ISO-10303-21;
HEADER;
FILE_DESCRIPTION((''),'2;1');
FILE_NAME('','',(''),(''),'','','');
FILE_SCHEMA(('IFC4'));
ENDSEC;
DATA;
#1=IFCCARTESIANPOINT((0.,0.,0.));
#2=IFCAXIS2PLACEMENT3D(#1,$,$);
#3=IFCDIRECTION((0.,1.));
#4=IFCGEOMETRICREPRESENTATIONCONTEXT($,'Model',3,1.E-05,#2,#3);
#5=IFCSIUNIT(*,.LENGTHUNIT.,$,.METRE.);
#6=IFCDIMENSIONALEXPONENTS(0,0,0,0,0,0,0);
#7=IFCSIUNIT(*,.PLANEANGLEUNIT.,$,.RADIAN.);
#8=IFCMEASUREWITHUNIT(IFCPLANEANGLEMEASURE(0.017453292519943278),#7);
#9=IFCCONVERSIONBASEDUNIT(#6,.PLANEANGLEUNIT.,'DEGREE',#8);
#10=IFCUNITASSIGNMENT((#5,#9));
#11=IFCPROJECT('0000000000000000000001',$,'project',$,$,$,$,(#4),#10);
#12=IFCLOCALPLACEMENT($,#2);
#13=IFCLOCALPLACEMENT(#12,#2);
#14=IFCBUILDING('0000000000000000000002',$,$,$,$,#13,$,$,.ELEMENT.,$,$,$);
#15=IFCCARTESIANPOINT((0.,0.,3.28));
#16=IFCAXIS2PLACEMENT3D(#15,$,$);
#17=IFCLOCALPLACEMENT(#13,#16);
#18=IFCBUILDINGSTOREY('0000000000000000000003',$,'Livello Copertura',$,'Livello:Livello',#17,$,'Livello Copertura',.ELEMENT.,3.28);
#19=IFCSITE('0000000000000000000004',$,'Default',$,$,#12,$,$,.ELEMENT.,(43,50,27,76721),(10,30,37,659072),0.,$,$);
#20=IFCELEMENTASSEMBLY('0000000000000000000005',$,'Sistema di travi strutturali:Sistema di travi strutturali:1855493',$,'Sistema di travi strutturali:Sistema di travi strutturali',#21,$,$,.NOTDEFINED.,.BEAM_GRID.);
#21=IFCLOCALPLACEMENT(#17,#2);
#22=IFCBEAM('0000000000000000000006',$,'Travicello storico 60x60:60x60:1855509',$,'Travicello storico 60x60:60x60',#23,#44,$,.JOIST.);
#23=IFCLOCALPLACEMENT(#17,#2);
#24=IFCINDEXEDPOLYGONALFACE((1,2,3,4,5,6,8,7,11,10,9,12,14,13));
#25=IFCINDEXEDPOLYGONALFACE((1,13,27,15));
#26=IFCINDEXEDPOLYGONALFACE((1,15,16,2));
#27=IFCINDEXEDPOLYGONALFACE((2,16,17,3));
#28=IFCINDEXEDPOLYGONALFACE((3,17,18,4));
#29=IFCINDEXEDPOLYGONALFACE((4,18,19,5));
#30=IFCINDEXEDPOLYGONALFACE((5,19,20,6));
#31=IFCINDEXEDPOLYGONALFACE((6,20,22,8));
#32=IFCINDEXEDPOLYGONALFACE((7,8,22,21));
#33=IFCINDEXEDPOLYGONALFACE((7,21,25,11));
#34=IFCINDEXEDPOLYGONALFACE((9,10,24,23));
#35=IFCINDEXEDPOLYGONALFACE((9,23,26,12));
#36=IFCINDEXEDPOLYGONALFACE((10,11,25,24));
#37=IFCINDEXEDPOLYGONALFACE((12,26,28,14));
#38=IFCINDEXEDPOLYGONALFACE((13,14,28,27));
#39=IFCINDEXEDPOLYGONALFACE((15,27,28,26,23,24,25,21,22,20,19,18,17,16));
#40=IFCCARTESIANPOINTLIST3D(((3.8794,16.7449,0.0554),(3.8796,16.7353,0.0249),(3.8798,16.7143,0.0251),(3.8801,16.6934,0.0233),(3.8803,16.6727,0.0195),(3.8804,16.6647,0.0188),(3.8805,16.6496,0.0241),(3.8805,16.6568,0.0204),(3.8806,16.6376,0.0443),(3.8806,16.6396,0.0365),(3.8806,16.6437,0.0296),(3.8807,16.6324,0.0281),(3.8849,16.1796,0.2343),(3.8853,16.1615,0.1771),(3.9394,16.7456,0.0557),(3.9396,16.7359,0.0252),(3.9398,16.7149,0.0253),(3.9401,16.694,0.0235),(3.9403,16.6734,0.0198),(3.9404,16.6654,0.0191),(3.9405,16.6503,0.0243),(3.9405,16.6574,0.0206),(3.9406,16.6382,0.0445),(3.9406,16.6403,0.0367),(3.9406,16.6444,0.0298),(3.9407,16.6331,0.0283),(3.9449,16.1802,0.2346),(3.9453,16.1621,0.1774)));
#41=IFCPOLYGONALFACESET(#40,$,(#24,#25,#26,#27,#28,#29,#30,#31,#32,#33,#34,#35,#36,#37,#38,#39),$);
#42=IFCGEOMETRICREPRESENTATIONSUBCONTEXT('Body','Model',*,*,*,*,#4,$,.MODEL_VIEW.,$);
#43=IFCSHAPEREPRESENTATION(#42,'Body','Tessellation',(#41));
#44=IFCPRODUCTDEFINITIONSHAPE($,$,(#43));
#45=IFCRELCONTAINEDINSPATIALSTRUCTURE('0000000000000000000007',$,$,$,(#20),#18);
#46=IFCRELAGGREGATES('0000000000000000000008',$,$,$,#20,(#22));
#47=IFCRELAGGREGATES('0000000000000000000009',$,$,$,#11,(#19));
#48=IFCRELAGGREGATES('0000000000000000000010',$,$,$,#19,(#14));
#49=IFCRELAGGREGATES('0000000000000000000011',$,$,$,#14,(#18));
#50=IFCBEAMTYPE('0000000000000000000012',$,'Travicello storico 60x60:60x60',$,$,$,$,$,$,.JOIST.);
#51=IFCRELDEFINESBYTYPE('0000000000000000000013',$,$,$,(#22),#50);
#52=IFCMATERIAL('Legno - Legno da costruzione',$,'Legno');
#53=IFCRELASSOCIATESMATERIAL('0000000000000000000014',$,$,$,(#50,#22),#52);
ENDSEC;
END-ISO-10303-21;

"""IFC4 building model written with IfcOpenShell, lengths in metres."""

from ifc_helpers import new_model, entity, si_unit, converted_unit, direction, frame, origin, place, context, subcontext, project, spatial, line, arc, indexed_curve, outline, extrude, source, transform, mapped, material, type_object, type_shapes, element, aggregate, save


model = new_model("IFC4")

# Units and contexts
model_context = context("Model", 3, precision=1e-05, world=origin(), true_north=direction((0.0, 1.0)))
body_context = subcontext(model_context, "Body", "Model", "MODEL_VIEW")
ifc_project = project(units=[si_unit("LENGTHUNIT", "METRE"), converted_unit("PLANEANGLEUNIT", "DEGREE", entity("IfcPlaneAngleMeasure", 0.017453292519943278), si_unit("PLANEANGLEUNIT", "RADIAN"), dimensions=[0, 0, 0, 0, 0, 0, 0])], contexts=[model_context])

# Site, building, storey
site_placement = place(None, origin())
site = spatial("IfcSite", under=ifc_project, at=site_placement, Name="Default", CompositionType="ELEMENT", RefLatitude=(43, 50, 27, 76721), RefLongitude=(10, 30, 37, 659072), RefElevation=0.0)
building_placement = place(site_placement, origin())
building = spatial("IfcBuilding", under=site, at=building_placement, CompositionType="ELEMENT")
storey_placement = place(building_placement, frame((0.0, 0.0, 3.28)))
storey = spatial("IfcBuildingStorey", under=building, at=storey_placement, Name="Livello Copertura", ObjectType="Livello:Livello", LongName="Livello Copertura", CompositionType="ELEMENT", Elevation=3.28)

# Element assembly, beam
ifc_material = material(Name="Legno - Legno da costruzione", Category="Legno")
assembly_1_placement = place(storey_placement, origin())
assembly_1 = element("IfcElementAssembly", 1, at=assembly_1_placement, inside=storey, Name="Sistema di travi strutturali:Sistema di travi strutturali:1855493", ObjectType="Sistema di travi strutturali:Sistema di travi strutturali", AssemblyPlace="NOTDEFINED", PredefinedType="BEAM_GRID")
beam_type_1 = type_object("IfcBeamType", Name="Travicello storico 60x60:60x60", PredefinedType="JOIST", material=ifc_material)
shared_shape_1 = source(origin(), body_context, "Body", "SweptSolid", [
    extrude(outline(indexed_curve([(-0.0359, -0.387), (0.0241, -0.387), (0.0241, 0.107), (0.0071, 0.107), (0.0228, 0.1246), (0.0201, 0.148), (0.0061, 0.1762), (-0.0039, 0.206), (-0.0359, 0.206)], segments=[line(1, 2, 3, 4), arc(4, 5, 6), arc(6, 7, 8), line(8, 9, 1)], self_intersect=False)), frame((0.0495, -0.03, -0.0059), z_axis=(0.0, 1.0, 0.0), x_axis=(0.0, 0.0, -1.0)), (0.0, 0.0, 1.0), 0.06),
])
type_shapes(beam_type_1, [shared_shape_1])
beam_1_placement = place(assembly_1_placement, frame((3.911, 16.587, 0.0742), z_axis=(-0.007187, 0.301619, 0.953402), x_axis=(0.009277, -0.953365, 0.301677)))
beam_1 = element("IfcBeam", 2, at=beam_1_placement, type_object=beam_type_1, material=ifc_material, Name="Travicello storico 60x60:60x60:1855509", ObjectType="Travicello storico 60x60:60x60", PredefinedType="JOIST", context=body_context, shape_type="MappedRepresentation", body=[
    mapped(shared_shape_1, transform((0.0, 0.0, 0.0), scale=1.0)),
])
aggregate(assembly_1, [beam_1])

save(model, "model.ifc")
